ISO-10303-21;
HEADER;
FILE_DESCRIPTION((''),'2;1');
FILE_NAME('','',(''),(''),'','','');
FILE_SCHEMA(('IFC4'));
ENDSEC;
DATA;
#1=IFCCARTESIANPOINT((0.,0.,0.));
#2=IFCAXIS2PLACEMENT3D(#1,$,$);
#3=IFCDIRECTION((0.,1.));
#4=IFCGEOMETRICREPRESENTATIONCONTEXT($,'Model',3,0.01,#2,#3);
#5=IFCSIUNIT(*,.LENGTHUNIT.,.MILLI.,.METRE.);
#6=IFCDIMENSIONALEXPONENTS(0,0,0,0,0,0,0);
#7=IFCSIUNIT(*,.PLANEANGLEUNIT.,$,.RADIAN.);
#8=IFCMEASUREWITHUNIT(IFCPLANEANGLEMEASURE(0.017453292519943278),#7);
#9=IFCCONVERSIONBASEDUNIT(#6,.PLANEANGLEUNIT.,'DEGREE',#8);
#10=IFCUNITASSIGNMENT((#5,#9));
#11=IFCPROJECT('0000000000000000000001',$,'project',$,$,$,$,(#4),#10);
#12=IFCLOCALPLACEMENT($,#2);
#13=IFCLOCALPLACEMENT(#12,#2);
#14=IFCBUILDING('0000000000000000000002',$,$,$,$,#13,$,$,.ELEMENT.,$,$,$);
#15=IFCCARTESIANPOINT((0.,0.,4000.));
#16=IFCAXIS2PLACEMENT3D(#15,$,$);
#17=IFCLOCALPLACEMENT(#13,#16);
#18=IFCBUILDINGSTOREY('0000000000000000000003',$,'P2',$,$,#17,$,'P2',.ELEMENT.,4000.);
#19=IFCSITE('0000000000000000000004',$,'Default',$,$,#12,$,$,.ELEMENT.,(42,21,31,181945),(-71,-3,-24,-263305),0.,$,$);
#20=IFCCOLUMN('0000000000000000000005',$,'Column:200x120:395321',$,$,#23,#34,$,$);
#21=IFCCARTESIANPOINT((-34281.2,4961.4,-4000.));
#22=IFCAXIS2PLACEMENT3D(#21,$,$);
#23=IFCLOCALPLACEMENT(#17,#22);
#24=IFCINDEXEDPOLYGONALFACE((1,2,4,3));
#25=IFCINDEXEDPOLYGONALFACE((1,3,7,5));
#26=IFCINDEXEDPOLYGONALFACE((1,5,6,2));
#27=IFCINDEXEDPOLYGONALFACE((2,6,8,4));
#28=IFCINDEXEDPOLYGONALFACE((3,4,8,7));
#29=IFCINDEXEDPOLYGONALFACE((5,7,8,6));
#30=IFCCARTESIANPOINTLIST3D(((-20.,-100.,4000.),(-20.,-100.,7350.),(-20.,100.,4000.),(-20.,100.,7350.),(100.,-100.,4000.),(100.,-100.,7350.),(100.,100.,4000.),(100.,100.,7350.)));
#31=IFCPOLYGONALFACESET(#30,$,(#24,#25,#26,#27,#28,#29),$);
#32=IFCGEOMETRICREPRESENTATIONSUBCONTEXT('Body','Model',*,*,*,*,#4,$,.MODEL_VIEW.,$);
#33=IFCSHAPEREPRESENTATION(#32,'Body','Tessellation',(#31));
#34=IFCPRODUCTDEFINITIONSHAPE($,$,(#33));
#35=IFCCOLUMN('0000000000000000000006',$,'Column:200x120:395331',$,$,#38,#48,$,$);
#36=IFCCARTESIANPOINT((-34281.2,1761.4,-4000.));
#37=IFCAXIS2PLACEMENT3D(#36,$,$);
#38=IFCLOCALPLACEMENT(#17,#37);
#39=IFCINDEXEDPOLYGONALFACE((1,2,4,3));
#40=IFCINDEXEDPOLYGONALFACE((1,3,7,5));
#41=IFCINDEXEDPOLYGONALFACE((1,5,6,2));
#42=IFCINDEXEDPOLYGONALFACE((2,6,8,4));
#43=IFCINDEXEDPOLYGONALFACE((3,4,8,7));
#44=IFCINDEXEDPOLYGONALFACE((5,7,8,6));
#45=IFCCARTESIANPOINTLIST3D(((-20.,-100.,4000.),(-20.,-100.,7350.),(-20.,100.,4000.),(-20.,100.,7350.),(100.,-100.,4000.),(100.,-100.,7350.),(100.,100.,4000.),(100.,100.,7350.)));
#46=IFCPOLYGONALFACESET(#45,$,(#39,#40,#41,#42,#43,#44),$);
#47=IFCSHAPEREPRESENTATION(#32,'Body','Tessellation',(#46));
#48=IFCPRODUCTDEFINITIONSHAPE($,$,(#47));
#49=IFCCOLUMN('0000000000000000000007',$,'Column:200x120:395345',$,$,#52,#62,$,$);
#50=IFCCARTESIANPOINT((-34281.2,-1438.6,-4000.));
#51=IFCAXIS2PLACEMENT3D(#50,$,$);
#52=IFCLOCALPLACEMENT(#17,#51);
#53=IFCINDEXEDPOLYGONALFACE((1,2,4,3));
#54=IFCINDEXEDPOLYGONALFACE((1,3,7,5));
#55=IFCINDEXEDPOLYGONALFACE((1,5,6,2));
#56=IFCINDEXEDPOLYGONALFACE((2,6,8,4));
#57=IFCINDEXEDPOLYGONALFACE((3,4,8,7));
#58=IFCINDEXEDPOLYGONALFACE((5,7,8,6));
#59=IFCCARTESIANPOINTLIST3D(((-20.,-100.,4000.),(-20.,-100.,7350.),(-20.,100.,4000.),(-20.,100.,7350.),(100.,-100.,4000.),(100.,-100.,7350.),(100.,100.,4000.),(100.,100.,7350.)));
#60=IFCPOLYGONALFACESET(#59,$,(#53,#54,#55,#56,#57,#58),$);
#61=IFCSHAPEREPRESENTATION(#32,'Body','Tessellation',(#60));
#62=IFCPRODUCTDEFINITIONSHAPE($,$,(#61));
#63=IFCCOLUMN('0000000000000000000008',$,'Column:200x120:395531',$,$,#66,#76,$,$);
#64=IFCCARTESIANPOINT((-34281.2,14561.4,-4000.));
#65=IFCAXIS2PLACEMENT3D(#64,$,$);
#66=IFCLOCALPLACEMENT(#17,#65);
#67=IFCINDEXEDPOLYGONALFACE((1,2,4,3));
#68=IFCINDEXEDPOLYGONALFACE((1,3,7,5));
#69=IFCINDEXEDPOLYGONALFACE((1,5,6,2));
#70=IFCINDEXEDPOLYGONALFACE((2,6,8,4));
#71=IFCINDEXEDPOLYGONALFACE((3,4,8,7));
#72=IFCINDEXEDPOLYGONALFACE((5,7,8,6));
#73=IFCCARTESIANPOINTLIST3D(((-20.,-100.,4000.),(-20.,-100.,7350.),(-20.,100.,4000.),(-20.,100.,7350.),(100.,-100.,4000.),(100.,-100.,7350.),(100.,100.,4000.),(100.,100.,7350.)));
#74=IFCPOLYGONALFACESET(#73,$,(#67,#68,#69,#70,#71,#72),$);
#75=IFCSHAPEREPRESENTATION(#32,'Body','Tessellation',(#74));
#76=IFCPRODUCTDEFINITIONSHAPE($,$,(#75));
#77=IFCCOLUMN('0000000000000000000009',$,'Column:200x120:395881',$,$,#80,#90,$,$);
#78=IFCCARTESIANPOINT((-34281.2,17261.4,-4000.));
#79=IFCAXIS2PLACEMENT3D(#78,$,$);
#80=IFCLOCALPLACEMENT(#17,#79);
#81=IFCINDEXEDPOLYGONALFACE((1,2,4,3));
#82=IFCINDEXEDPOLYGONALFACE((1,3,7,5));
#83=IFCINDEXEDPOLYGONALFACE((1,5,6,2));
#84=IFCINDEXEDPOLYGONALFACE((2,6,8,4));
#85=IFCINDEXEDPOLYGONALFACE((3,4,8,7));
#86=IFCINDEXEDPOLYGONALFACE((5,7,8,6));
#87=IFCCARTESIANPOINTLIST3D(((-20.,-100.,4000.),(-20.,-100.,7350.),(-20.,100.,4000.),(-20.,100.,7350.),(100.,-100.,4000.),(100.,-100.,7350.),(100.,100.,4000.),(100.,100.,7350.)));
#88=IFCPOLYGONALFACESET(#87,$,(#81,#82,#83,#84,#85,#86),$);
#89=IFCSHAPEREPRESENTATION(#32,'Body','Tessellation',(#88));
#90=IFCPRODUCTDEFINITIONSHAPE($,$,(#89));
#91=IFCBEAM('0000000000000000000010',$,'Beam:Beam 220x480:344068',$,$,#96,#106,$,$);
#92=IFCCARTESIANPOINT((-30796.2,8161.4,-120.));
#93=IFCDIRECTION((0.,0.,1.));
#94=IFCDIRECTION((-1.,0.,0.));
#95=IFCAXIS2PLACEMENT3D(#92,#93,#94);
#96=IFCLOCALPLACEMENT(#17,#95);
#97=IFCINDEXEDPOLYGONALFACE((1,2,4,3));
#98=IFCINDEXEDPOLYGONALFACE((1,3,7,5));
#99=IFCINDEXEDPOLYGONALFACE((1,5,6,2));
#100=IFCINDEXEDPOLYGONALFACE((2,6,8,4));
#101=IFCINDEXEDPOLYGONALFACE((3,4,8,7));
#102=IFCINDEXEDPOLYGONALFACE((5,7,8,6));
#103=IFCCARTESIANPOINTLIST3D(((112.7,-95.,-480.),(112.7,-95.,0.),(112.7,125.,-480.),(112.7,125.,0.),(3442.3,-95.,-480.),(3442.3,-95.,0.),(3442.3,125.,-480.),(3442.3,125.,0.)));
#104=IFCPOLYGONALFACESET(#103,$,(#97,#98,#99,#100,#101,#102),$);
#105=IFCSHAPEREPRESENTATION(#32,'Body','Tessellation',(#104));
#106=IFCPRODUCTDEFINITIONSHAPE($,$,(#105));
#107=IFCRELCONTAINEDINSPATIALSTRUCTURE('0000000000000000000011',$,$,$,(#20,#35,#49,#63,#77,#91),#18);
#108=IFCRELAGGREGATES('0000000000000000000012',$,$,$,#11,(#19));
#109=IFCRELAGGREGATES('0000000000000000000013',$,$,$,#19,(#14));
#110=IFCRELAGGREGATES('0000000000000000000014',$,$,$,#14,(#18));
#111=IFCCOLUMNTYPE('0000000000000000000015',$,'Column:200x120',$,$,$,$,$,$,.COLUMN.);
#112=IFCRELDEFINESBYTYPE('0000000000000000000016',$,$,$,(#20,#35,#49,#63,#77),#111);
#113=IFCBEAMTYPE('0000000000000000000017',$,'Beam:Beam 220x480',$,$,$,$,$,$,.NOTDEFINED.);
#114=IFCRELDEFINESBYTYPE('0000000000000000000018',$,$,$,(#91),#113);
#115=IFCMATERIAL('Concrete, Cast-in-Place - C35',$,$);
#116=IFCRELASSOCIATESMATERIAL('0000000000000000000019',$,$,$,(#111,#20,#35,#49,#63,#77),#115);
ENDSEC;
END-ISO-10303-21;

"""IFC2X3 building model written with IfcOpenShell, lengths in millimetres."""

from ifc_helpers import new_model, entity, si_unit, converted_unit, direction, frame, frame_2d, origin, origin_2d_with_axis, place, context, subcontext, project, spatial, rectangle, extrude, source, transform, mapped, material, type_object, type_shapes, element, save


model = new_model("IFC2X3")

# Units and contexts
model_context = context("Model", 3, precision=0.01, world=origin(), true_north=direction((0.0, 1.0)))
body_context = subcontext(model_context, "Body", "Model", "MODEL_VIEW")
ifc_project = project(units=[si_unit("LENGTHUNIT", "METRE", prefix="MILLI"), converted_unit("PLANEANGLEUNIT", "DEGREE", entity("IfcPlaneAngleMeasure", 0.017453292519943278), si_unit("PLANEANGLEUNIT", "RADIAN"), dimensions=[0, 0, 0, 0, 0, 0, 0])], contexts=[model_context])

# Site, building, storey
site_placement = place(None, origin())
site = spatial("IfcSite", under=ifc_project, at=site_placement, Name="Default", CompositionType="ELEMENT", RefLatitude=(42, 21, 31, 181945), RefLongitude=(-71, -3, -24, -263305), RefElevation=0.0)
building_placement = place(site_placement, origin())
building = spatial("IfcBuilding", under=site, at=building_placement, CompositionType="ELEMENT")
storey_placement = place(building_placement, frame((0.0, 0.0, 4000.0)))
storey = spatial("IfcBuildingStorey", under=building, at=storey_placement, Name="P2", LongName="P2", CompositionType="ELEMENT", Elevation=4000.0)

# Columns
ifc_material = material(Name="Concrete, Cast-in-Place - C35")
column_type_1 = type_object("IfcColumnType", Name="Column:200x120", PredefinedType="COLUMN", material=ifc_material)
shared_shape_1 = source(origin(), body_context, "Body", "SweptSolid", [
    extrude(rectangle(XDim=120.0, YDim=200.0, at=origin_2d_with_axis()), frame((40.0, 0.0, 4000.0), z_axis=(0.0, 0.0, 1.0), x_axis=(-1.0, 0.0, 0.0)), (0.0, 0.0, 1.0), 3350.0),
])
type_shapes(column_type_1, [shared_shape_1])
for number, where, name in (
    (1, (-34281.2, 4961.4, -4000.0), "Column:200x120:395321"),
    (2, (-34281.2, 1761.4, -4000.0), "Column:200x120:395331"),
    (3, (-34281.2, -1438.6, -4000.0), "Column:200x120:395345"),
    (4, (-34281.2, 14561.4, -4000.0), "Column:200x120:395531"),
    (5, (-34281.2, 17261.4, -4000.0), "Column:200x120:395881"),
):
    element("IfcColumn", number, at=place(storey_placement, frame(where)), inside=storey, type_object=column_type_1, material=ifc_material, Name=name, context=body_context, shape_type="MappedRepresentation", body=[
        mapped(shared_shape_1, transform((0.0, 0.0, 0.0), scale=1.0)),
    ])

# Beam
beam_type_1 = type_object("IfcBeamType", Name="Beam:Beam 220x480", PredefinedType="NOTDEFINED")
beam_1_placement = place(storey_placement, frame((-30796.2, 8161.4, -120.0), z_axis=(0.0, 0.0, 1.0), x_axis=(-1.0, 0.0, 0.0)))
element("IfcBeam", 6, at=beam_1_placement, inside=storey, type_object=beam_type_1, Name="Beam:Beam 220x480:344068", context=body_context, shape_type="SweptSolid", body=[
    extrude(rectangle(XDim=480.0, YDim=220.0, at=frame_2d((0.0, 0.0), x_axis=(1.0, 0.0))), frame((112.7, 15.0, -240.0), z_axis=(1.0, 0.0, 0.0), x_axis=(0.0, 0.0, -1.0)), (0.0, 0.0, 1.0), 3329.6),
])

save(model, "model.ifc")
